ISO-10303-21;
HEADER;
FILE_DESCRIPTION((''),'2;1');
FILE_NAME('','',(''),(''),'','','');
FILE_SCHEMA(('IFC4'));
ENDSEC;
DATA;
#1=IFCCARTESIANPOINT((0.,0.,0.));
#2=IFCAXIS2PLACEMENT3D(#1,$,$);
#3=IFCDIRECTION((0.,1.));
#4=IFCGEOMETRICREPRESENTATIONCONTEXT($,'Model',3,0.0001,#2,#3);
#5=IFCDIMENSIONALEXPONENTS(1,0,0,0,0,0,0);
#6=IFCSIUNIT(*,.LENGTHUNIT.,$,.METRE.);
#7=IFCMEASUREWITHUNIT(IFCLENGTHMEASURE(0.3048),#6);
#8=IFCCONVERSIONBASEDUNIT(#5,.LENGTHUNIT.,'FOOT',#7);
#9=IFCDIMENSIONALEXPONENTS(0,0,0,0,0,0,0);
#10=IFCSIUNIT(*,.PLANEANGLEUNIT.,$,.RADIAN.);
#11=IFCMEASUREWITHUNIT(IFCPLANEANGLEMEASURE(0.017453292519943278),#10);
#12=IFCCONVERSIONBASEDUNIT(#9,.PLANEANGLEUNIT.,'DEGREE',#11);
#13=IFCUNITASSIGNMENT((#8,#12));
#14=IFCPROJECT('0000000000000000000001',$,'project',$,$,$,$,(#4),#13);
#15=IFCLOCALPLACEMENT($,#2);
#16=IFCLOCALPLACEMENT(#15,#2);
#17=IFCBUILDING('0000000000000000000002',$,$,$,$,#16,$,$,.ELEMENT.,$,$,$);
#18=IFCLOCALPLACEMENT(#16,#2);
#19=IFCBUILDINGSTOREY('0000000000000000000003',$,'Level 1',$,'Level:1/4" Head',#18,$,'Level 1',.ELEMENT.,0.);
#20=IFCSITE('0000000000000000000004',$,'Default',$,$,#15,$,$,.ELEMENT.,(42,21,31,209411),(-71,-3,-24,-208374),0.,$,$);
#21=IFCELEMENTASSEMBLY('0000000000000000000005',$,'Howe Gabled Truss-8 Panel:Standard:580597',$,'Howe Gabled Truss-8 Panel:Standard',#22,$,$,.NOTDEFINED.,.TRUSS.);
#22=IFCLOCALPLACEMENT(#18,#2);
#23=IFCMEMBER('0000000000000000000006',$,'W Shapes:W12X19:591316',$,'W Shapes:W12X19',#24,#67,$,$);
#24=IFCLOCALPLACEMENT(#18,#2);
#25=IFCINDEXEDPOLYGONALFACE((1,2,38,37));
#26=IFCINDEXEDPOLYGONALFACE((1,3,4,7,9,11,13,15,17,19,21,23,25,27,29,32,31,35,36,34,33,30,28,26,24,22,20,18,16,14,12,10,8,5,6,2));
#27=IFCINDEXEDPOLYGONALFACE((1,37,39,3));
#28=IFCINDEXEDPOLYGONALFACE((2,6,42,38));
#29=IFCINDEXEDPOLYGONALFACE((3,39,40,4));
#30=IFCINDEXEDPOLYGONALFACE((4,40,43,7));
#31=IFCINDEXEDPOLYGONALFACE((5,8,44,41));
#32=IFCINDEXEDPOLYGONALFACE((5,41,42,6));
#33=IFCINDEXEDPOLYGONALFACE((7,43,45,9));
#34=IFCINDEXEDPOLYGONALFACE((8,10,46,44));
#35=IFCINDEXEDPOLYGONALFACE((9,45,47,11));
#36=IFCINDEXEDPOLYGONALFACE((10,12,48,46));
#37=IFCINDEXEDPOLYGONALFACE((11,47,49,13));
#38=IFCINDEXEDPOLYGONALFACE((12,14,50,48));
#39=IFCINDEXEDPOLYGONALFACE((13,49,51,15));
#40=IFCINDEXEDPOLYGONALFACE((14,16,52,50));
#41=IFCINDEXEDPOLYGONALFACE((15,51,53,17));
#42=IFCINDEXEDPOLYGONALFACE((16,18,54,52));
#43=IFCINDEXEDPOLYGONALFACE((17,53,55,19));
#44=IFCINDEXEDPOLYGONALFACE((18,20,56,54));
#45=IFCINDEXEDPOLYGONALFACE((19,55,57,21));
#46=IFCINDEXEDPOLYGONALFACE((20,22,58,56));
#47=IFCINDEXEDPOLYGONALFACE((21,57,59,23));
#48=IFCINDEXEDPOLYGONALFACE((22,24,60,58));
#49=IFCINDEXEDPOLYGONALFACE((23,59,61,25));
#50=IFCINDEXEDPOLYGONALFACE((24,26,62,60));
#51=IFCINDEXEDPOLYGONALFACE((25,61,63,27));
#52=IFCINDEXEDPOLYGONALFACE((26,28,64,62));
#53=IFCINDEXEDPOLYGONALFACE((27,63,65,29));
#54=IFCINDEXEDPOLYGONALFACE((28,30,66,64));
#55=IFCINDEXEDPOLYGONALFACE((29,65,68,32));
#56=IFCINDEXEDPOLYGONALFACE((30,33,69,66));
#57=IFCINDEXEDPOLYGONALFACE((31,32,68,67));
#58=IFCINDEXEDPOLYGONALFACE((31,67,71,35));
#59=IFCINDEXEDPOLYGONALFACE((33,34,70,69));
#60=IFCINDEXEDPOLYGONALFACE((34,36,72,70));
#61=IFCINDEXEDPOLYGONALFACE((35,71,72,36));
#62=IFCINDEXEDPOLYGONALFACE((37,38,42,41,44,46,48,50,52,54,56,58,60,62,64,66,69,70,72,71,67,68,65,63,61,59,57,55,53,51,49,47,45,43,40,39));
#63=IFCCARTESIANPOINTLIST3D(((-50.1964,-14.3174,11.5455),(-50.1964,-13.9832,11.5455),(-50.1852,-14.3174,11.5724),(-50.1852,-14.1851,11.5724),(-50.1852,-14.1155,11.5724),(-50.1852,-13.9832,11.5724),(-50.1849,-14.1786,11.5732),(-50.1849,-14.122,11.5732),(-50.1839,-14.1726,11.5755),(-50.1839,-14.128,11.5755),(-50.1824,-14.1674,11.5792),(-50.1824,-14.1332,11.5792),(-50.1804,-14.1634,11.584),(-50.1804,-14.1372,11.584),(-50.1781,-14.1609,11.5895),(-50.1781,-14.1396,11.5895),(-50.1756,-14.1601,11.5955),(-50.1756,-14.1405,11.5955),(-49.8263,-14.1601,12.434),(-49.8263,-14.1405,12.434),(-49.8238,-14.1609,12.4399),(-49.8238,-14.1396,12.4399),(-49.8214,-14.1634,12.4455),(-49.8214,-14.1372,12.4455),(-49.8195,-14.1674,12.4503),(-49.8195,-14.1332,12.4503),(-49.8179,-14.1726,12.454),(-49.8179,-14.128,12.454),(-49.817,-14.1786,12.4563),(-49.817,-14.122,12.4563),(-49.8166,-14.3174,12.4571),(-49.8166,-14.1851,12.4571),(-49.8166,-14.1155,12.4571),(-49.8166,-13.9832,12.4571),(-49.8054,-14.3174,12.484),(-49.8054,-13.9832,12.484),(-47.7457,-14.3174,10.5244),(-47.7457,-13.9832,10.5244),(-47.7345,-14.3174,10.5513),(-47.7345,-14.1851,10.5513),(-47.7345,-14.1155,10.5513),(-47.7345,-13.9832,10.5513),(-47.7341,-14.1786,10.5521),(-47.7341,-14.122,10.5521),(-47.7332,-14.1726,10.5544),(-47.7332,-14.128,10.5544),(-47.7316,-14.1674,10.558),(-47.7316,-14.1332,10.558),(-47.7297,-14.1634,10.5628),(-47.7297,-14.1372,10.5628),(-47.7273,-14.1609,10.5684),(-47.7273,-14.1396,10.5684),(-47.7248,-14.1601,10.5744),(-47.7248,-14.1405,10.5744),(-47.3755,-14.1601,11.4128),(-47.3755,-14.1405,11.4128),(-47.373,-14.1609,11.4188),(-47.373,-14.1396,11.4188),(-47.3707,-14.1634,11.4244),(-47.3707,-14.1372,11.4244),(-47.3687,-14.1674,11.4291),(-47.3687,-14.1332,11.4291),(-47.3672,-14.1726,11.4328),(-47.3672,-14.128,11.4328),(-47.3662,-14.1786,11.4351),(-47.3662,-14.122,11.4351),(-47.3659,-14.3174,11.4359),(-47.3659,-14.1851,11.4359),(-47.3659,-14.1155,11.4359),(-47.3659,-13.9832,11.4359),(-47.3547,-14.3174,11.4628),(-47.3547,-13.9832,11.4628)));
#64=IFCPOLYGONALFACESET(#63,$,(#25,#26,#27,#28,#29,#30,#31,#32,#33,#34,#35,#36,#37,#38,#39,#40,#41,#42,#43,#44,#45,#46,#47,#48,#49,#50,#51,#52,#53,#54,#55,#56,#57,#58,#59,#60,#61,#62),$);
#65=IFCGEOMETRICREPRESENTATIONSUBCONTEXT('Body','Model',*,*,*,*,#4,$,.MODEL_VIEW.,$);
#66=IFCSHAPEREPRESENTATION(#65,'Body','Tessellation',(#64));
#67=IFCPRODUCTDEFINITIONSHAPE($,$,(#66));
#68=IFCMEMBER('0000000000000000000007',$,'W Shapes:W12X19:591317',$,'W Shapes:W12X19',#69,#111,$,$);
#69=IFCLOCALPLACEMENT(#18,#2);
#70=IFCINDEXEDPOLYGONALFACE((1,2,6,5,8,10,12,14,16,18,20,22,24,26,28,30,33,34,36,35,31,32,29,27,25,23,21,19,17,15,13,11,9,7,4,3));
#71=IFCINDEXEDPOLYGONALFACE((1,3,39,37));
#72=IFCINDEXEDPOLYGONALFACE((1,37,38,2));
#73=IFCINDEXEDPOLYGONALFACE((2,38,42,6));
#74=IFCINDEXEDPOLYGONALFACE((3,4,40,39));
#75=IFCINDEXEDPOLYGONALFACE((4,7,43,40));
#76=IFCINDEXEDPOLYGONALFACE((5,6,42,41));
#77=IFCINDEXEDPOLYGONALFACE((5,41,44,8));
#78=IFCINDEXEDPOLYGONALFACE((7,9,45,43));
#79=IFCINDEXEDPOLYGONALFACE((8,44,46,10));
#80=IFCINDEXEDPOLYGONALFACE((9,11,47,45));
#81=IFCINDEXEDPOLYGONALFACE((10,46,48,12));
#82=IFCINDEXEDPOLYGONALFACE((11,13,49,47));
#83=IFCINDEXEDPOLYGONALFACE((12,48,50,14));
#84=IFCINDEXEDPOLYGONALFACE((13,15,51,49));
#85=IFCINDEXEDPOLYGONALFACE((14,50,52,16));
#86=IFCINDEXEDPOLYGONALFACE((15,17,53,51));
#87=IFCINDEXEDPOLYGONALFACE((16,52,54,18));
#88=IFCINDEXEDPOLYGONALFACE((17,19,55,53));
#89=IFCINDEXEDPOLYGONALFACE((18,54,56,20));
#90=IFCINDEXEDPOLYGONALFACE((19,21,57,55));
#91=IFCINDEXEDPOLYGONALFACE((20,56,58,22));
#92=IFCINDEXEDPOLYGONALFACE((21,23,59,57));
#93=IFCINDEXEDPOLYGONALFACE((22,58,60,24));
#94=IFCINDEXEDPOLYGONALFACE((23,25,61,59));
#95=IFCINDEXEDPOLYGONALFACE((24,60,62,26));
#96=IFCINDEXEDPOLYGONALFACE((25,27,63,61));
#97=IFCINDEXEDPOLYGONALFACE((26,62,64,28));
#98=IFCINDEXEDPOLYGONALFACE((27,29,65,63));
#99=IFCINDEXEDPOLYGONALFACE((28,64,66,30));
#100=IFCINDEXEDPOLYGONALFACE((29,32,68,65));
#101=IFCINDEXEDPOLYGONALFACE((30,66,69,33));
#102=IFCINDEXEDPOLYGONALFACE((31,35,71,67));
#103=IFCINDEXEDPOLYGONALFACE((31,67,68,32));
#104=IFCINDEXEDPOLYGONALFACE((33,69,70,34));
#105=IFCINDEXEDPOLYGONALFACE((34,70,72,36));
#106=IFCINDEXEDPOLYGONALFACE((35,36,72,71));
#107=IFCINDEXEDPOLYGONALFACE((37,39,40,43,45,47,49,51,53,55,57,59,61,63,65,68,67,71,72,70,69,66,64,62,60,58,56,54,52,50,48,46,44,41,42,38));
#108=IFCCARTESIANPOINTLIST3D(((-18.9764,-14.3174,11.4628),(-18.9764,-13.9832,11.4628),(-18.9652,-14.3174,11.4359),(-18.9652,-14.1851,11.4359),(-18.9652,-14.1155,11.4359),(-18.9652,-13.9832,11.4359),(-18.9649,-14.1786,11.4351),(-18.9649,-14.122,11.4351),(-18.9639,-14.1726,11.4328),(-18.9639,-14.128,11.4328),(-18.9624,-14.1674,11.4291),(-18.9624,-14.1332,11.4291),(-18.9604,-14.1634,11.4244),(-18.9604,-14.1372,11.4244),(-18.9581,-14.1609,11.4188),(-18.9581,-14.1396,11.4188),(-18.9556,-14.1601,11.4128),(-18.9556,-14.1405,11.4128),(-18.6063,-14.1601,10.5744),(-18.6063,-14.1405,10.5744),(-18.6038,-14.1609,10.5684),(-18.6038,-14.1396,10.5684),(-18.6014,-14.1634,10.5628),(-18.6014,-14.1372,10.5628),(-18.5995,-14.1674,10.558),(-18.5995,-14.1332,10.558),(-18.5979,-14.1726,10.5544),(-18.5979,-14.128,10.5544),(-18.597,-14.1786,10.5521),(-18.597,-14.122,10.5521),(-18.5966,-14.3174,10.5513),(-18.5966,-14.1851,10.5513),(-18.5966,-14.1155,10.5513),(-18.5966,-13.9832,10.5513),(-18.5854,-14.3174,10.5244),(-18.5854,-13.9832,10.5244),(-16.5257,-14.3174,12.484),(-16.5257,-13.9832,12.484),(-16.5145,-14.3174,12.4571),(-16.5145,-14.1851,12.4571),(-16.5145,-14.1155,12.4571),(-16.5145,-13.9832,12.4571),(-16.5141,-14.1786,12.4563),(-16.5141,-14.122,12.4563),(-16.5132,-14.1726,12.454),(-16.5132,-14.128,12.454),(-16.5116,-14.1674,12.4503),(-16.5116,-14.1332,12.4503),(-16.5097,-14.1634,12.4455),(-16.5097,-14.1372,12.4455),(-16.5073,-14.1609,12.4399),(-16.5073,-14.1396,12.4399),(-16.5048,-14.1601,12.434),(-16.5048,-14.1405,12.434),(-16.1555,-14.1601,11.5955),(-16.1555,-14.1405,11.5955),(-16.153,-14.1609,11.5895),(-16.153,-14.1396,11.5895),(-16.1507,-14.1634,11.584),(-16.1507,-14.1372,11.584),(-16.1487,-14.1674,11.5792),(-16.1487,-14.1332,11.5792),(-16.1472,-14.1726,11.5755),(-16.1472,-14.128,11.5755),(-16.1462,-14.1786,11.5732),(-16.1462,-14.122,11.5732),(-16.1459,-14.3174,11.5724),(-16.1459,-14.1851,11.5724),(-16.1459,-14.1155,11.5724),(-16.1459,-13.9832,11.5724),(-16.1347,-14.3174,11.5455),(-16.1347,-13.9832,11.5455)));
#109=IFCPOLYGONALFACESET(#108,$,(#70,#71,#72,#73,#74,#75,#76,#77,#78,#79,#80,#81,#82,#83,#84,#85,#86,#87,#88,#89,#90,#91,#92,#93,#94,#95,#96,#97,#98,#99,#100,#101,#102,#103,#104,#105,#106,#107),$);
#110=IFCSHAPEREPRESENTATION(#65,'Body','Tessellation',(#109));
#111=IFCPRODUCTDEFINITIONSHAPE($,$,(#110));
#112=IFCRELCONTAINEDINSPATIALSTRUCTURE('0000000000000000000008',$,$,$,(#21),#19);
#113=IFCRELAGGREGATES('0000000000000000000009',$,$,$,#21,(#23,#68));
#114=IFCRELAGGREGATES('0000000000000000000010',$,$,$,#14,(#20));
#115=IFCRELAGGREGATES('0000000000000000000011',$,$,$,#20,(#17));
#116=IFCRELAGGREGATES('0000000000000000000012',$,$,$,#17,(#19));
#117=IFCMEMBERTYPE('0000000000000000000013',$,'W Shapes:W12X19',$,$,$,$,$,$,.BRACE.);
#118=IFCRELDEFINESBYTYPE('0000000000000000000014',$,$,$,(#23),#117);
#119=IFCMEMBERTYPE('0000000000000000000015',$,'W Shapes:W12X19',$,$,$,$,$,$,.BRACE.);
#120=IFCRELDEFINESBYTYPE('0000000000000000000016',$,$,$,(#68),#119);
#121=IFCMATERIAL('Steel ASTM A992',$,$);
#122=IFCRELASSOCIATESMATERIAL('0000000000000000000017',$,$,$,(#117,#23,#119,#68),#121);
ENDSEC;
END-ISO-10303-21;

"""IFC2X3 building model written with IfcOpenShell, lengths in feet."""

from ifc_helpers import new_model, entity, si_unit, converted_unit, direction, frame, frame_2d, origin, place, context, subcontext, project, spatial, polyline, circle_curve, parameter, trimmed, segment, composite_curve, outline, extrude, source, transform, mapped, material, type_object, type_shapes, element, aggregate, save


model = new_model("IFC2X3")

# Units and contexts
model_context = context("Model", 3, precision=0.0001, world=origin(), true_north=direction((0.0, 1.0)))
body_context = subcontext(model_context, "Body", "Model", "MODEL_VIEW")
ifc_project = project(units=[converted_unit("LENGTHUNIT", "FOOT", entity("IfcLengthMeasure", 0.3048), si_unit("LENGTHUNIT", "METRE"), dimensions=[1, 0, 0, 0, 0, 0, 0]), converted_unit("PLANEANGLEUNIT", "DEGREE", entity("IfcPlaneAngleMeasure", 0.017453292519943278), si_unit("PLANEANGLEUNIT", "RADIAN"), dimensions=[0, 0, 0, 0, 0, 0, 0])], contexts=[model_context])

# Site, building, storey
site_placement = place(None, origin())
site = spatial("IfcSite", under=ifc_project, at=site_placement, Name="Default", CompositionType="ELEMENT", RefLatitude=(42, 21, 31, 209411), RefLongitude=(-71, -3, -24, -208374), RefElevation=0.0)
building_placement = place(site_placement, origin())
building = spatial("IfcBuilding", under=site, at=building_placement, CompositionType="ELEMENT")
storey_placement = place(building_placement, origin())
storey = spatial("IfcBuildingStorey", under=building, at=storey_placement, Name="Level 1", ObjectType="Level:1/4\" Head", LongName="Level 1", CompositionType="ELEMENT", Elevation=0.0)

# Element assembly, members
assembly_placement = place(storey_placement, origin())
assembly = element("IfcElementAssembly", 1, at=assembly_placement, inside=storey, Name="Howe Gabled Truss-8 Panel:Standard:580597", ObjectType="Howe Gabled Truss-8 Panel:Standard", AssemblyPlace="NOTDEFINED", PredefinedType="TRUSS")
ifc_material = material(Name="Steel ASTM A992")
member_type_1 = type_object("IfcMemberType", Name="W Shapes:W12X19", PredefinedType="BRACE", material=ifc_material)
shared_shape_1 = source(origin(), body_context, "Body", "SweptSolid", [
    extrude(outline(composite_curve([segment(polyline([(-0.1671, -0.4792), (-0.1671, -0.5083)]), True, "CONTINUOUS"), segment(polyline([(-0.1671, -0.5083), (0.1671, -0.5083)]), True, "CONTINUOUS"), segment(polyline([(0.1671, -0.5083), (0.1671, -0.4792)]), True, "CONTINUOUS"), segment(polyline([(0.1671, -0.4792), (0.0348, -0.4792)]), True, "CONTINUOUS"), segment(trimmed(circle_curve(frame_2d((0.0348, -0.4542), x_axis=(0.0, -1.0)), 0.025), [parameter(270.0)], [parameter(360.0)], True, "PARAMETER"), False, "CONTINUOUS"), segment(polyline([(0.0098, -0.4542), (0.0098, 0.4542)]), True, "CONTINUOUS"), segment(trimmed(circle_curve(frame_2d((0.0348, 0.4542), x_axis=(-1.0, 0.0)), 0.025), [parameter(270.0)], [parameter(360.0)], True, "PARAMETER"), False, "CONTINUOUS"), segment(polyline([(0.0348, 0.4792), (0.1671, 0.4792)]), True, "CONTINUOUS"), segment(polyline([(0.1671, 0.4792), (0.1671, 0.5083)]), True, "CONTINUOUS"), segment(polyline([(0.1671, 0.5083), (-0.1671, 0.5083)]), True, "CONTINUOUS"), segment(polyline([(-0.1671, 0.5083), (-0.1671, 0.4792)]), True, "CONTINUOUS"), segment(polyline([(-0.1671, 0.4792), (-0.0348, 0.4792)]), True, "CONTINUOUS"), segment(trimmed(circle_curve(frame_2d((-0.0348, 0.4542), x_axis=(0.0, 1.0)), 0.025), [parameter(270.0)], [parameter(0.0)], True, "PARAMETER"), False, "CONTINUOUS"), segment(polyline([(-0.0098, 0.4542), (-0.0098, -0.4542)]), True, "CONTINUOUS"), segment(trimmed(circle_curve(frame_2d((-0.0348, -0.4542), x_axis=(1.0, 0.0)), 0.025), [parameter(270.0)], [parameter(0.0)], True, "PARAMETER"), False, "CONTINUOUS"), segment(polyline([(-0.0348, -0.4792), (-0.1671, -0.4792)]), True, "CONTINUOUS")], self_intersect=False)), frame((-1.9883, 0.0, 0.0), z_axis=(-1.0, 0.0, 0.0), x_axis=(0.0, -1.0, 0.0)), (0.0, 0.0, -1.0), 2.655),
])
type_shapes(member_type_1, [shared_shape_1])
member_1_placement = place(assembly_placement, frame((-48.1655, -14.1503, 11.25), z_axis=(-0.384615, 0.0, -0.923077), x_axis=(0.923077, 0.0, -0.384615)))
member_1 = element("IfcMember", 2, at=member_1_placement, type_object=member_type_1, material=ifc_material, Name="W Shapes:W12X19:591316", ObjectType="W Shapes:W12X19", context=body_context, shape_type="MappedRepresentation", body=[
    mapped(shared_shape_1, transform((0.0, 0.0, 0.0), scale=1.0)),
])
member_type_2 = type_object("IfcMemberType", Name="W Shapes:W12X19", PredefinedType="BRACE", material=ifc_material)
shared_shape_2 = source(origin(), body_context, "Body", "SweptSolid", [
    extrude(outline(composite_curve([segment(polyline([(-0.1671, -0.4792), (-0.1671, -0.5083)]), True, "CONTINUOUS"), segment(polyline([(-0.1671, -0.5083), (0.1671, -0.5083)]), True, "CONTINUOUS"), segment(polyline([(0.1671, -0.5083), (0.1671, -0.4792)]), True, "CONTINUOUS"), segment(polyline([(0.1671, -0.4792), (0.0348, -0.4792)]), True, "CONTINUOUS"), segment(trimmed(circle_curve(frame_2d((0.0348, -0.4542), x_axis=(0.0, -1.0)), 0.025), [parameter(270.0)], [parameter(360.0)], True, "PARAMETER"), False, "CONTINUOUS"), segment(polyline([(0.0098, -0.4542), (0.0098, 0.4542)]), True, "CONTINUOUS"), segment(trimmed(circle_curve(frame_2d((0.0348, 0.4542), x_axis=(-1.0, 0.0)), 0.025), [parameter(270.0)], [parameter(360.0)], True, "PARAMETER"), False, "CONTINUOUS"), segment(polyline([(0.0348, 0.4792), (0.1671, 0.4792)]), True, "CONTINUOUS"), segment(polyline([(0.1671, 0.4792), (0.1671, 0.5083)]), True, "CONTINUOUS"), segment(polyline([(0.1671, 0.5083), (-0.1671, 0.5083)]), True, "CONTINUOUS"), segment(polyline([(-0.1671, 0.5083), (-0.1671, 0.4792)]), True, "CONTINUOUS"), segment(polyline([(-0.1671, 0.4792), (-0.0348, 0.4792)]), True, "CONTINUOUS"), segment(trimmed(circle_curve(frame_2d((-0.0348, 0.4542), x_axis=(0.0, 1.0)), 0.025), [parameter(270.0)], [parameter(0.0)], True, "PARAMETER"), False, "CONTINUOUS"), segment(polyline([(-0.0098, 0.4542), (-0.0098, -0.4542)]), True, "CONTINUOUS"), segment(trimmed(circle_curve(frame_2d((-0.0348, -0.4542), x_axis=(1.0, 0.0)), 0.025), [parameter(270.0)], [parameter(0.0)], True, "PARAMETER"), False, "CONTINUOUS"), segment(polyline([(-0.0348, -0.4792), (-0.1671, -0.4792)]), True, "CONTINUOUS")], self_intersect=False)), frame((-0.6667, 0.0, 0.0), z_axis=(-1.0, 0.0, 0.0), x_axis=(0.0, -1.0, 0.0)), (0.0, 0.0, -1.0), 2.655),
])
type_shapes(member_type_2, [shared_shape_2])
member_2_placement = place(assembly_placement, frame((-18.1655, -14.1503, 11.25), z_axis=(0.384615, 0.0, -0.923077), x_axis=(0.923077, 0.0, 0.384615)))
member_2 = element("IfcMember", 3, at=member_2_placement, type_object=member_type_2, material=ifc_material, Name="W Shapes:W12X19:591317", ObjectType="W Shapes:W12X19", context=body_context, shape_type="MappedRepresentation", body=[
    mapped(shared_shape_2, transform((0.0, 0.0, 0.0), scale=1.0)),
])
aggregate(assembly, [member_1, member_2])

save(model, "model.ifc")
